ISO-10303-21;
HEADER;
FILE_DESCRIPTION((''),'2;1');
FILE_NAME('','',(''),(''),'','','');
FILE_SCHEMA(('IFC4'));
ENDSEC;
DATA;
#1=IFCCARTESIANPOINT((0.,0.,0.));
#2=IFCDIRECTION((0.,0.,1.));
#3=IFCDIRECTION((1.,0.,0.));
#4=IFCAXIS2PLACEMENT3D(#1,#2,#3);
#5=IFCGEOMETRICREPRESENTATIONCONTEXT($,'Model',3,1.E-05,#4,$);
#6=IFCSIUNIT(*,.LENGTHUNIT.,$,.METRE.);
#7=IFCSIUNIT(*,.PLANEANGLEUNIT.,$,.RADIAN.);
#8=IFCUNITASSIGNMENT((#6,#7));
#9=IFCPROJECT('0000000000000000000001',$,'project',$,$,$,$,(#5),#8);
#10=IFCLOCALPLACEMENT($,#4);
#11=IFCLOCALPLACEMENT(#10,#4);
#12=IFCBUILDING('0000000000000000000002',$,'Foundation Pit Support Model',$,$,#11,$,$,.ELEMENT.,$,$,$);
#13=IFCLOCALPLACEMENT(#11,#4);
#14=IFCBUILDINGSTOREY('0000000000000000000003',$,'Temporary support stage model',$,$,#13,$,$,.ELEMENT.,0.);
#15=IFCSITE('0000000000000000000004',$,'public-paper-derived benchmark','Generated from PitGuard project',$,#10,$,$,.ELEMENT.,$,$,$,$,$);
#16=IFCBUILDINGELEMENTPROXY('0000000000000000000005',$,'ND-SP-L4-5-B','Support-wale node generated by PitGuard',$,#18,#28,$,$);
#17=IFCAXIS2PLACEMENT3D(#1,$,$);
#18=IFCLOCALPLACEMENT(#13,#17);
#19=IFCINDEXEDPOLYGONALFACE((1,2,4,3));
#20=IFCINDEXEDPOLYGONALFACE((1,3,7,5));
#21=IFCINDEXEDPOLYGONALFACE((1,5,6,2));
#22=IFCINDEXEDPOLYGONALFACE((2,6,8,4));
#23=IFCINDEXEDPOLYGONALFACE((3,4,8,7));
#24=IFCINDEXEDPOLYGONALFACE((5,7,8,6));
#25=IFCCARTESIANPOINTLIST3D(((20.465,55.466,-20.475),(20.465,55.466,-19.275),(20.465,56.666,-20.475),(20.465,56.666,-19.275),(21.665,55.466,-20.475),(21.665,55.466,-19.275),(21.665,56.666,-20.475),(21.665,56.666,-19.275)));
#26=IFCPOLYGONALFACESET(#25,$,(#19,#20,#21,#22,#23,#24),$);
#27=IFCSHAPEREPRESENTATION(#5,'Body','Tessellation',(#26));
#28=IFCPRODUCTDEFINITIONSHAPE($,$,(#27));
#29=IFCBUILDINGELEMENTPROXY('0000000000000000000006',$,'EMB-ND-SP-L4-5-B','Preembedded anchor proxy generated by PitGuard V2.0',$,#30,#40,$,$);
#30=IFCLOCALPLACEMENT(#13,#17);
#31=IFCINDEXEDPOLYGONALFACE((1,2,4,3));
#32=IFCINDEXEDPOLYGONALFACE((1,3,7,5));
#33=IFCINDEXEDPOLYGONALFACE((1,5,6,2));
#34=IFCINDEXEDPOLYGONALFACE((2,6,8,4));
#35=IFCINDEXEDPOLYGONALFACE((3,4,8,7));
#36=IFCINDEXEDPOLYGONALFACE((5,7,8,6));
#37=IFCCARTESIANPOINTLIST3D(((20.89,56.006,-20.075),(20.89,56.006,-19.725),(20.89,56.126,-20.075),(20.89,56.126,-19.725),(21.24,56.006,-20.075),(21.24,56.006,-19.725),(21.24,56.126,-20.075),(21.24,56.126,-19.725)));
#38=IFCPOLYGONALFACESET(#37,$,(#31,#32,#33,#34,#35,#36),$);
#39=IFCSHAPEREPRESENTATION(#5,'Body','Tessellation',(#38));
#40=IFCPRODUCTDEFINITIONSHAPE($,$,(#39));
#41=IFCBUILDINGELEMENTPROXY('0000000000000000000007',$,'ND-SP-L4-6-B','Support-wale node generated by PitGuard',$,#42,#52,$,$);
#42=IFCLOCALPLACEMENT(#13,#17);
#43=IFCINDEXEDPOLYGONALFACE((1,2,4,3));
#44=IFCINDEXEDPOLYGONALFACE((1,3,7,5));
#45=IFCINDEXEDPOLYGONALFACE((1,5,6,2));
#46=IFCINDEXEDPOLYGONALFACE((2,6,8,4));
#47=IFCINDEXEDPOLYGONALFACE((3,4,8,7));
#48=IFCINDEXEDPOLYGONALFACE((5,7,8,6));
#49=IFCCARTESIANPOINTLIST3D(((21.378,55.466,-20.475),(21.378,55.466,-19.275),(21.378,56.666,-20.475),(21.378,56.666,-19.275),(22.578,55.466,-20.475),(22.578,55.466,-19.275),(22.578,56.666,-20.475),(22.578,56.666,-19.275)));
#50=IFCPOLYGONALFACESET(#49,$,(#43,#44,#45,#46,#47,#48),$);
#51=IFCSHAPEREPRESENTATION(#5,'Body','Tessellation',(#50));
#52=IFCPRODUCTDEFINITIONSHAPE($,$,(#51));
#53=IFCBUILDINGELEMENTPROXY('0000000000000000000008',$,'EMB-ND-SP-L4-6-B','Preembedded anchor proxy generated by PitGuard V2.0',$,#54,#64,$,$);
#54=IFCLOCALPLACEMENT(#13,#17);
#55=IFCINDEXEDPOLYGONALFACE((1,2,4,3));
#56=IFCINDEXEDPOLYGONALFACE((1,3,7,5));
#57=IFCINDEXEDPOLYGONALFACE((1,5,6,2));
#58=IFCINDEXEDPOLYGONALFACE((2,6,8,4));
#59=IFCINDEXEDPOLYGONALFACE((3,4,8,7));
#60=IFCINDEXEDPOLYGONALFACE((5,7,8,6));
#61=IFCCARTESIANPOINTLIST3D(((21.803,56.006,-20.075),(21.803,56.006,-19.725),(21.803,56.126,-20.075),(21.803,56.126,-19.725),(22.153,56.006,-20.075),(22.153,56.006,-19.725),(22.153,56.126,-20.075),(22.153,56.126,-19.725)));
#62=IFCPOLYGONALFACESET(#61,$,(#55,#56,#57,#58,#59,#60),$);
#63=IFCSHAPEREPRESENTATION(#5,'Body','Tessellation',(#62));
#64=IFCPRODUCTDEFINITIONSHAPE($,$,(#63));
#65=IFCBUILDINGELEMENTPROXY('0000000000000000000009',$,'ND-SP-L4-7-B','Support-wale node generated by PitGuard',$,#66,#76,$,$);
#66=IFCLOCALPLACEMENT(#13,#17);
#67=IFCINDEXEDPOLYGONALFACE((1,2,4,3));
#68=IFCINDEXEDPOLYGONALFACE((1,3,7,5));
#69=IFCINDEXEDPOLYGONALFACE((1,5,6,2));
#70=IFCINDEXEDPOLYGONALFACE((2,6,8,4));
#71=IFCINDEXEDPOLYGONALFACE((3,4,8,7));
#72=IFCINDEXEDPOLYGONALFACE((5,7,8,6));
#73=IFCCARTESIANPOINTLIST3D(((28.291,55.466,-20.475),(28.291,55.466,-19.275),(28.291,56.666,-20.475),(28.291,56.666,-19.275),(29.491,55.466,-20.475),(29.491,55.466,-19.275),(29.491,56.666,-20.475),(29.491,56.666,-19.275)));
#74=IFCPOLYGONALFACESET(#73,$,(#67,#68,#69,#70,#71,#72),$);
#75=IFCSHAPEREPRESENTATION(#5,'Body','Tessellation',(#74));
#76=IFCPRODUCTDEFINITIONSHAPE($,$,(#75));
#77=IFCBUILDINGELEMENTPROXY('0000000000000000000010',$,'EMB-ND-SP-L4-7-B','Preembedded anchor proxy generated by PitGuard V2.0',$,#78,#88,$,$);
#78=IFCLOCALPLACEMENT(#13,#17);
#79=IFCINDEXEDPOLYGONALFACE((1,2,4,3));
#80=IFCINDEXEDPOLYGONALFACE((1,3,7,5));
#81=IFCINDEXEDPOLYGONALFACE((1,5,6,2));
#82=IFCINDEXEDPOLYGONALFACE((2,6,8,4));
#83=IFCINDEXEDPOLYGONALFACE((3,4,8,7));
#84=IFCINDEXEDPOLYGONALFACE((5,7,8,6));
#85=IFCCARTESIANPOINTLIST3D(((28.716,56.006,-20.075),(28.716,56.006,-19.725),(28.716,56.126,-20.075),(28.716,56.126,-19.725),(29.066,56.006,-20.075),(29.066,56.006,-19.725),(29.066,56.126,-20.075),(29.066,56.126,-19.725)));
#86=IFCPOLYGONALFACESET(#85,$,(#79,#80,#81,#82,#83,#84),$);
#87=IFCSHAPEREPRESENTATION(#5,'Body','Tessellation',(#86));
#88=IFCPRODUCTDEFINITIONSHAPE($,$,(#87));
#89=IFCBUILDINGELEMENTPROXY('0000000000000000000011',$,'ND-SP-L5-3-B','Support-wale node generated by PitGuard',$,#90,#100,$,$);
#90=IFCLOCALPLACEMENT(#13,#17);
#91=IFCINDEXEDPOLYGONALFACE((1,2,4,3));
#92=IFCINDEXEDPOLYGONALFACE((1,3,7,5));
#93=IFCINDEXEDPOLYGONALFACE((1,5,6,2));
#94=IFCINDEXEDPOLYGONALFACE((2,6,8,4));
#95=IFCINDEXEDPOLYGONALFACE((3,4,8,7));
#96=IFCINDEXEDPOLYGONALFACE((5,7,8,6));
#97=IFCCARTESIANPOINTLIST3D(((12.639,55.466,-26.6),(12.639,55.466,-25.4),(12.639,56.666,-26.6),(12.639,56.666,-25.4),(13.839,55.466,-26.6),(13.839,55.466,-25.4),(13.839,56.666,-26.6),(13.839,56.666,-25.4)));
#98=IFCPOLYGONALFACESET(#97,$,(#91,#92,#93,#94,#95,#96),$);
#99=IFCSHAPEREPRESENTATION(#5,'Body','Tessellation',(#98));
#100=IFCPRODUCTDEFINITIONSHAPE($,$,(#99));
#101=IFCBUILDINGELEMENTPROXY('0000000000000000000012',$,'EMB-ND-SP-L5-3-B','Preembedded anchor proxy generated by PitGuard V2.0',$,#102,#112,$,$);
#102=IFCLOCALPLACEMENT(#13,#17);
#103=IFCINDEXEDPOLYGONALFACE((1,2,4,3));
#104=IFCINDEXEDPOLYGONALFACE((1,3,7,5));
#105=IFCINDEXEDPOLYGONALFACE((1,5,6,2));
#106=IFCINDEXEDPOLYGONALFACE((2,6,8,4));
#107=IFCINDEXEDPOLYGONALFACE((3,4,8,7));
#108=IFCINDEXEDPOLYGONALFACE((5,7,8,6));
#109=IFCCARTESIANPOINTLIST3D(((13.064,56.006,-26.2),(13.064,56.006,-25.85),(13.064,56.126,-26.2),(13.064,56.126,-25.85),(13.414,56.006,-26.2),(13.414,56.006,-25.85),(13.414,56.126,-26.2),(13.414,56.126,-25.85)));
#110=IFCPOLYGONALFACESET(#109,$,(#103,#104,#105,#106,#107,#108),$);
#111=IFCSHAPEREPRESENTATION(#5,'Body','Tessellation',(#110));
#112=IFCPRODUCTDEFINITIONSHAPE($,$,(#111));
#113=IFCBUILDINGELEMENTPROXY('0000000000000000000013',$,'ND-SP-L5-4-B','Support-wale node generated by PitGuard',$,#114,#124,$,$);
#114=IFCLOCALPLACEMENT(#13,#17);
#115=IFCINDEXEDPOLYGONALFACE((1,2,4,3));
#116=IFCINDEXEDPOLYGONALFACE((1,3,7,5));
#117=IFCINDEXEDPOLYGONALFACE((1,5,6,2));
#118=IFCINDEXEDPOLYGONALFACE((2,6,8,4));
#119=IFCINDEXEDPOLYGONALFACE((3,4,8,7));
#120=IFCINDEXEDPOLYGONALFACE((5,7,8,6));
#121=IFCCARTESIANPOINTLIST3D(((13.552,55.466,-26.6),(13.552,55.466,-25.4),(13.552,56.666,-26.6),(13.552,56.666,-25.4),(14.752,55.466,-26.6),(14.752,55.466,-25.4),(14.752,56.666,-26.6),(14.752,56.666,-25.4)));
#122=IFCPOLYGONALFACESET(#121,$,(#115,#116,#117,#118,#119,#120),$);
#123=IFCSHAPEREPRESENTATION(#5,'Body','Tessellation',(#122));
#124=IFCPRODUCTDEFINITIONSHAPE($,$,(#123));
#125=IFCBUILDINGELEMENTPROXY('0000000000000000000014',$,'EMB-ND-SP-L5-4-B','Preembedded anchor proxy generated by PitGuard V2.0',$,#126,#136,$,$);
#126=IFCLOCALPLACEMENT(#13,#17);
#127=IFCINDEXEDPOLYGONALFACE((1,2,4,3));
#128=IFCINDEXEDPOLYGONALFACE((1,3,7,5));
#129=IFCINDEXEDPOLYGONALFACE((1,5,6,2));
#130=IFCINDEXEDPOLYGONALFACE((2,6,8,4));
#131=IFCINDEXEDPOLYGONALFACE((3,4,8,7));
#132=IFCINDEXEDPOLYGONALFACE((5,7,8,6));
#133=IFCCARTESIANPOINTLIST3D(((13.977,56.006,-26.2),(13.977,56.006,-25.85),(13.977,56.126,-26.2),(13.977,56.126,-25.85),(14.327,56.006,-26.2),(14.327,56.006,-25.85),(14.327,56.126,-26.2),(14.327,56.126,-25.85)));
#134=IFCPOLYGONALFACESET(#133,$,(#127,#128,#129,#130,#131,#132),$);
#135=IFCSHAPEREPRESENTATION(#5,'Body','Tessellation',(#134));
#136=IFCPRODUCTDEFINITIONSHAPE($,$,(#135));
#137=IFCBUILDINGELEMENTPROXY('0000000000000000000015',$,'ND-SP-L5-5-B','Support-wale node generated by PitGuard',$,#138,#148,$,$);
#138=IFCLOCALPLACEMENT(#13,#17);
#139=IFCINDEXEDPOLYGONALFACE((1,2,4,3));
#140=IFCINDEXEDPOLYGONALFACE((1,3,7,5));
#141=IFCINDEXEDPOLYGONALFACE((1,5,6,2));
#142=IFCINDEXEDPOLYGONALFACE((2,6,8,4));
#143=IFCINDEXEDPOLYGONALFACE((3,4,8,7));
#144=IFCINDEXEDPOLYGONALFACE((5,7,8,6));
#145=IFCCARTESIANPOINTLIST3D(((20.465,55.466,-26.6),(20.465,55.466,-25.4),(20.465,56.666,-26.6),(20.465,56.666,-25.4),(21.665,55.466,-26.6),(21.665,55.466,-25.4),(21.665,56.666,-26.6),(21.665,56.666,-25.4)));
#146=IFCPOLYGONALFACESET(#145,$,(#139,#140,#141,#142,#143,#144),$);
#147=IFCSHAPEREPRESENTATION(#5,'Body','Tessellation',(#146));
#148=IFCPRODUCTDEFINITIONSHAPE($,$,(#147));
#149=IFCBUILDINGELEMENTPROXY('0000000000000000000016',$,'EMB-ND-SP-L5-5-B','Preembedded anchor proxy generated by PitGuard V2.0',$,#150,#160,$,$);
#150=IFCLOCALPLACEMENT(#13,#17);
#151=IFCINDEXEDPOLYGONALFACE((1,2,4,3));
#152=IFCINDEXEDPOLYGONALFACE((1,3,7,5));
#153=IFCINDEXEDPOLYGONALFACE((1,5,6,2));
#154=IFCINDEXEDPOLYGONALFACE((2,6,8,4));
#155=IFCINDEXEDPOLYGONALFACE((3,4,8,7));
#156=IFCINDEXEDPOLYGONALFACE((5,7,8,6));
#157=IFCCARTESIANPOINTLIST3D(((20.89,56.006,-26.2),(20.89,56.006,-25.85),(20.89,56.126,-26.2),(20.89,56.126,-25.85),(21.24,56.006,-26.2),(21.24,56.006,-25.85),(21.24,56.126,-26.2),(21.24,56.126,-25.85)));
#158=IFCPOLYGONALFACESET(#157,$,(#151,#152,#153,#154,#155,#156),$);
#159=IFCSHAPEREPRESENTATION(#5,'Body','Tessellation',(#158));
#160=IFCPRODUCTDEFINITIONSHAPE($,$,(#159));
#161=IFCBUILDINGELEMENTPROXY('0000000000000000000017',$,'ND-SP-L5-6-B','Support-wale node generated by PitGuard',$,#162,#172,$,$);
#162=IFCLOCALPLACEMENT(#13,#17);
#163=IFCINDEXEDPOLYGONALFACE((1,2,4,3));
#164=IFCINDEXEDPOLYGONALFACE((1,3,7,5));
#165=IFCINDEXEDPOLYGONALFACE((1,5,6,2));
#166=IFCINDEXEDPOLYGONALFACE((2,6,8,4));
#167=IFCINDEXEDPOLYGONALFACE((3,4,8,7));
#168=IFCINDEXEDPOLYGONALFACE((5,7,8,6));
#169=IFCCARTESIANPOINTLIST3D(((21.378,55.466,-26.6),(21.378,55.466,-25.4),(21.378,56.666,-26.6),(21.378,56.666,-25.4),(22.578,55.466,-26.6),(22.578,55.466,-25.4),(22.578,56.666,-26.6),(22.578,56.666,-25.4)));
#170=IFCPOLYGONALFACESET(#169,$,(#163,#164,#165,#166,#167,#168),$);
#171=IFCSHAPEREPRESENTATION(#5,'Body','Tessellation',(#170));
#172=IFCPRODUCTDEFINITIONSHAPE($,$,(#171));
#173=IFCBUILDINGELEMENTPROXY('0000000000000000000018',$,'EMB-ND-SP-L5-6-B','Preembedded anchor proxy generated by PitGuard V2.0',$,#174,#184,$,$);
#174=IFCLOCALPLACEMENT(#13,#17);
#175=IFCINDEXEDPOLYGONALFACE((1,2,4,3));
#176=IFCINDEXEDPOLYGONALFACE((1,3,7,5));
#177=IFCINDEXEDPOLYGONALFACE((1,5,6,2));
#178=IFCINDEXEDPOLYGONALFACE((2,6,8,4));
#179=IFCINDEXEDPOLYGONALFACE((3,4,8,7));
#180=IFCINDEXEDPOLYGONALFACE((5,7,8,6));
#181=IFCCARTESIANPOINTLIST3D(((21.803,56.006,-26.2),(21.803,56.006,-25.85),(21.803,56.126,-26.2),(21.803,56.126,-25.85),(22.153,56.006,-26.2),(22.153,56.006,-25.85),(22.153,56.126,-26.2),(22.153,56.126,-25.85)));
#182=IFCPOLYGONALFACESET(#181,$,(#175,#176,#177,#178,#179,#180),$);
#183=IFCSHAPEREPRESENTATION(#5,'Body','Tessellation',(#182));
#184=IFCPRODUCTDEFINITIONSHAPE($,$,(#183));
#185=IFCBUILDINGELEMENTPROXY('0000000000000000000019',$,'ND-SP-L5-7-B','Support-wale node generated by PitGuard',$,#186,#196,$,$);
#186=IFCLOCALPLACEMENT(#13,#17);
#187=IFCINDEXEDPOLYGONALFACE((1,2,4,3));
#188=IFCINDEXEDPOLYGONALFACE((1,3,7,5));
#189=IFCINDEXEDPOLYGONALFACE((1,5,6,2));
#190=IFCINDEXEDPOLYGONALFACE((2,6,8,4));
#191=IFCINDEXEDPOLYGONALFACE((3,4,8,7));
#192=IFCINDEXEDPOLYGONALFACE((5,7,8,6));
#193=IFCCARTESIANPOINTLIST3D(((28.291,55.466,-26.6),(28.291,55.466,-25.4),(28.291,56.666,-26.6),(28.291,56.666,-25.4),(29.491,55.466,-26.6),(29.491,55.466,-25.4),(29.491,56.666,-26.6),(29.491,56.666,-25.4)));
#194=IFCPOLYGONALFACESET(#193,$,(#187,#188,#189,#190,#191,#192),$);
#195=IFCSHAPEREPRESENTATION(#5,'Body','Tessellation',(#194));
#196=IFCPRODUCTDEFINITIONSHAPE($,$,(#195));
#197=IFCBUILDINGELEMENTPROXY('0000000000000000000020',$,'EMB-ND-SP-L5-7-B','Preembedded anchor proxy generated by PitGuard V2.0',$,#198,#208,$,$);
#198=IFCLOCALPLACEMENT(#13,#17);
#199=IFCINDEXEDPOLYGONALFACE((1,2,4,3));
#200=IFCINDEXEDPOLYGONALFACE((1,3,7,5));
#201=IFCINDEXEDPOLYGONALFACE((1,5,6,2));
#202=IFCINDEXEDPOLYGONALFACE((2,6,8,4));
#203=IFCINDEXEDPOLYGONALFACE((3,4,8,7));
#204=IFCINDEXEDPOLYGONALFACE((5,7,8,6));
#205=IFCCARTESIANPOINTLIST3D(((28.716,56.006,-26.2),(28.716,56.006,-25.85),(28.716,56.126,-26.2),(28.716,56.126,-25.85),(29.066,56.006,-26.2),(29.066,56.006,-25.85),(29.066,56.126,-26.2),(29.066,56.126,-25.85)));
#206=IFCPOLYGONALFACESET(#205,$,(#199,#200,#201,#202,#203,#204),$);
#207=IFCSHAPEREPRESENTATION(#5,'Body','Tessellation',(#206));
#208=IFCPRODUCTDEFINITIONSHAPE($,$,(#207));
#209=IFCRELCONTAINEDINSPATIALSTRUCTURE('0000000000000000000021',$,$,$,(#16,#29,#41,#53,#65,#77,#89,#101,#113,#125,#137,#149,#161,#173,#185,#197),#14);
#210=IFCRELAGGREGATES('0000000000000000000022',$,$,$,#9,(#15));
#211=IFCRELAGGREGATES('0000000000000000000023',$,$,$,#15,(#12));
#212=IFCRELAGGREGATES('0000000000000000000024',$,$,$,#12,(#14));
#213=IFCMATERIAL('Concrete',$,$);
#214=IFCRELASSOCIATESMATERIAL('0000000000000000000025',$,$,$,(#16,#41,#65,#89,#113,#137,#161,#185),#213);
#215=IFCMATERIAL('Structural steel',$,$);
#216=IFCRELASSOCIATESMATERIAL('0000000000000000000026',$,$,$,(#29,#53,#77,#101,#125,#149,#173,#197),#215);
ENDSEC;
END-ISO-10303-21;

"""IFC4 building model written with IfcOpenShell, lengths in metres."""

from ifc_helpers import new_model, si_unit, frame, origin_with_axes, origin_2d, place, context, project, spatial, rectangle, extrude, material, element, save


model = new_model("IFC4")

# Units and contexts
model_context = context("Model", 3, precision=1e-05, world=origin_with_axes())
ifc_project = project(units=[si_unit("LENGTHUNIT", "METRE"), si_unit("PLANEANGLEUNIT", "RADIAN")], contexts=[model_context])

# Site, building, storey
site_placement = place(None, origin_with_axes())
site = spatial("IfcSite", under=ifc_project, at=site_placement, Name="public-paper-derived benchmark", Description="Generated from PitGuard project", CompositionType="ELEMENT")
building_placement = place(site_placement, origin_with_axes())
building = spatial("IfcBuilding", under=site, at=building_placement, Name="Foundation Pit Support Model", CompositionType="ELEMENT")
storey_placement = place(building_placement, origin_with_axes())
storey = spatial("IfcBuildingStorey", under=building, at=storey_placement, Name="Temporary support stage model", CompositionType="ELEMENT", Elevation=0.0)

# Shared definitions
ifc_material_1 = material(Name="Structural steel")

# Building element proxies
ifc_material_2 = material(Name="Concrete")
proxy_1_placement = place(storey_placement, frame((21.065, 56.066, -20.475), z_axis=(0.0, 0.0, 1.0), x_axis=(1.0, 0.0, 0.0)))
element("IfcBuildingElementProxy", 1, at=proxy_1_placement, inside=storey, material=ifc_material_2, Name="ND-SP-L4-5-B", Description="Support-wale node generated by PitGuard", context=model_context, shape_type="SweptSolid", body=[
    extrude(rectangle(XDim=1.2, YDim=1.2, at=origin_2d()), origin_with_axes(), (0.0, 0.0, 1.0), 1.2),
])
proxy_2_placement = place(storey_placement, frame((21.065, 56.066, -20.075), z_axis=(0.0, 0.0, 1.0), x_axis=(1.0, 0.0, 0.0)))
element("IfcBuildingElementProxy", 2, at=proxy_2_placement, inside=storey, material=ifc_material_1, Name="EMB-ND-SP-L4-5-B", Description="Preembedded anchor proxy generated by PitGuard V2.0", context=model_context, shape_type="SweptSolid", body=[
    extrude(rectangle(XDim=0.35, YDim=0.12, at=origin_2d()), origin_with_axes(), (0.0, 0.0, 1.0), 0.35),
])
proxy_3_placement = place(storey_placement, frame((21.978, 56.066, -20.475), z_axis=(0.0, 0.0, 1.0), x_axis=(1.0, 0.0, 0.0)))
element("IfcBuildingElementProxy", 3, at=proxy_3_placement, inside=storey, material=ifc_material_2, Name="ND-SP-L4-6-B", Description="Support-wale node generated by PitGuard", context=model_context, shape_type="SweptSolid", body=[
    extrude(rectangle(XDim=1.2, YDim=1.2, at=origin_2d()), origin_with_axes(), (0.0, 0.0, 1.0), 1.2),
])
proxy_4_placement = place(storey_placement, frame((21.978, 56.066, -20.075), z_axis=(0.0, 0.0, 1.0), x_axis=(1.0, 0.0, 0.0)))
element("IfcBuildingElementProxy", 4, at=proxy_4_placement, inside=storey, material=ifc_material_1, Name="EMB-ND-SP-L4-6-B", Description="Preembedded anchor proxy generated by PitGuard V2.0", context=model_context, shape_type="SweptSolid", body=[
    extrude(rectangle(XDim=0.35, YDim=0.12, at=origin_2d()), origin_with_axes(), (0.0, 0.0, 1.0), 0.35),
])
proxy_5_placement = place(storey_placement, frame((28.891, 56.066, -20.475), z_axis=(0.0, 0.0, 1.0), x_axis=(1.0, 0.0, 0.0)))
element("IfcBuildingElementProxy", 5, at=proxy_5_placement, inside=storey, material=ifc_material_2, Name="ND-SP-L4-7-B", Description="Support-wale node generated by PitGuard", context=model_context, shape_type="SweptSolid", body=[
    extrude(rectangle(XDim=1.2, YDim=1.2, at=origin_2d()), origin_with_axes(), (0.0, 0.0, 1.0), 1.2),
])
proxy_6_placement = place(storey_placement, frame((28.891, 56.066, -20.075), z_axis=(0.0, 0.0, 1.0), x_axis=(1.0, 0.0, 0.0)))
element("IfcBuildingElementProxy", 6, at=proxy_6_placement, inside=storey, material=ifc_material_1, Name="EMB-ND-SP-L4-7-B", Description="Preembedded anchor proxy generated by PitGuard V2.0", context=model_context, shape_type="SweptSolid", body=[
    extrude(rectangle(XDim=0.35, YDim=0.12, at=origin_2d()), origin_with_axes(), (0.0, 0.0, 1.0), 0.35),
])
proxy_7_placement = place(storey_placement, frame((13.239, 56.066, -26.6), z_axis=(0.0, 0.0, 1.0), x_axis=(1.0, 0.0, 0.0)))
element("IfcBuildingElementProxy", 7, at=proxy_7_placement, inside=storey, material=ifc_material_2, Name="ND-SP-L5-3-B", Description="Support-wale node generated by PitGuard", context=model_context, shape_type="SweptSolid", body=[
    extrude(rectangle(XDim=1.2, YDim=1.2, at=origin_2d()), origin_with_axes(), (0.0, 0.0, 1.0), 1.2),
])
proxy_8_placement = place(storey_placement, frame((13.239, 56.066, -26.2), z_axis=(0.0, 0.0, 1.0), x_axis=(1.0, 0.0, 0.0)))
element("IfcBuildingElementProxy", 8, at=proxy_8_placement, inside=storey, material=ifc_material_1, Name="EMB-ND-SP-L5-3-B", Description="Preembedded anchor proxy generated by PitGuard V2.0", context=model_context, shape_type="SweptSolid", body=[
    extrude(rectangle(XDim=0.35, YDim=0.12, at=origin_2d()), origin_with_axes(), (0.0, 0.0, 1.0), 0.35),
])
proxy_9_placement = place(storey_placement, frame((14.152, 56.066, -26.6), z_axis=(0.0, 0.0, 1.0), x_axis=(1.0, 0.0, 0.0)))
element("IfcBuildingElementProxy", 9, at=proxy_9_placement, inside=storey, material=ifc_material_2, Name="ND-SP-L5-4-B", Description="Support-wale node generated by PitGuard", context=model_context, shape_type="SweptSolid", body=[
    extrude(rectangle(XDim=1.2, YDim=1.2, at=origin_2d()), origin_with_axes(), (0.0, 0.0, 1.0), 1.2),
])
proxy_10_placement = place(storey_placement, frame((14.152, 56.066, -26.2), z_axis=(0.0, 0.0, 1.0), x_axis=(1.0, 0.0, 0.0)))
element("IfcBuildingElementProxy", 10, at=proxy_10_placement, inside=storey, material=ifc_material_1, Name="EMB-ND-SP-L5-4-B", Description="Preembedded anchor proxy generated by PitGuard V2.0", context=model_context, shape_type="SweptSolid", body=[
    extrude(rectangle(XDim=0.35, YDim=0.12, at=origin_2d()), origin_with_axes(), (0.0, 0.0, 1.0), 0.35),
])
proxy_11_placement = place(storey_placement, frame((21.065, 56.066, -26.6), z_axis=(0.0, 0.0, 1.0), x_axis=(1.0, 0.0, 0.0)))
element("IfcBuildingElementProxy", 11, at=proxy_11_placement, inside=storey, material=ifc_material_2, Name="ND-SP-L5-5-B", Description="Support-wale node generated by PitGuard", context=model_context, shape_type="SweptSolid", body=[
    extrude(rectangle(XDim=1.2, YDim=1.2, at=origin_2d()), origin_with_axes(), (0.0, 0.0, 1.0), 1.2),
])
proxy_12_placement = place(storey_placement, frame((21.065, 56.066, -26.2), z_axis=(0.0, 0.0, 1.0), x_axis=(1.0, 0.0, 0.0)))
element("IfcBuildingElementProxy", 12, at=proxy_12_placement, inside=storey, material=ifc_material_1, Name="EMB-ND-SP-L5-5-B", Description="Preembedded anchor proxy generated by PitGuard V2.0", context=model_context, shape_type="SweptSolid", body=[
    extrude(rectangle(XDim=0.35, YDim=0.12, at=origin_2d()), origin_with_axes(), (0.0, 0.0, 1.0), 0.35),
])
proxy_13_placement = place(storey_placement, frame((21.978, 56.066, -26.6), z_axis=(0.0, 0.0, 1.0), x_axis=(1.0, 0.0, 0.0)))
element("IfcBuildingElementProxy", 13, at=proxy_13_placement, inside=storey, material=ifc_material_2, Name="ND-SP-L5-6-B", Description="Support-wale node generated by PitGuard", context=model_context, shape_type="SweptSolid", body=[
    extrude(rectangle(XDim=1.2, YDim=1.2, at=origin_2d()), origin_with_axes(), (0.0, 0.0, 1.0), 1.2),
])
proxy_14_placement = place(storey_placement, frame((21.978, 56.066, -26.2), z_axis=(0.0, 0.0, 1.0), x_axis=(1.0, 0.0, 0.0)))
element("IfcBuildingElementProxy", 14, at=proxy_14_placement, inside=storey, material=ifc_material_1, Name="EMB-ND-SP-L5-6-B", Description="Preembedded anchor proxy generated by PitGuard V2.0", context=model_context, shape_type="SweptSolid", body=[
    extrude(rectangle(XDim=0.35, YDim=0.12, at=origin_2d()), origin_with_axes(), (0.0, 0.0, 1.0), 0.35),
])
proxy_15_placement = place(storey_placement, frame((28.891, 56.066, -26.6), z_axis=(0.0, 0.0, 1.0), x_axis=(1.0, 0.0, 0.0)))
element("IfcBuildingElementProxy", 15, at=proxy_15_placement, inside=storey, material=ifc_material_2, Name="ND-SP-L5-7-B", Description="Support-wale node generated by PitGuard", context=model_context, shape_type="SweptSolid", body=[
    extrude(rectangle(XDim=1.2, YDim=1.2, at=origin_2d()), origin_with_axes(), (0.0, 0.0, 1.0), 1.2),
])
proxy_16_placement = place(storey_placement, frame((28.891, 56.066, -26.2), z_axis=(0.0, 0.0, 1.0), x_axis=(1.0, 0.0, 0.0)))
element("IfcBuildingElementProxy", 16, at=proxy_16_placement, inside=storey, material=ifc_material_1, Name="EMB-ND-SP-L5-7-B", Description="Preembedded anchor proxy generated by PitGuard V2.0", context=model_context, shape_type="SweptSolid", body=[
    extrude(rectangle(XDim=0.35, YDim=0.12, at=origin_2d()), origin_with_axes(), (0.0, 0.0, 1.0), 0.35),
])

save(model, "model.ifc")
